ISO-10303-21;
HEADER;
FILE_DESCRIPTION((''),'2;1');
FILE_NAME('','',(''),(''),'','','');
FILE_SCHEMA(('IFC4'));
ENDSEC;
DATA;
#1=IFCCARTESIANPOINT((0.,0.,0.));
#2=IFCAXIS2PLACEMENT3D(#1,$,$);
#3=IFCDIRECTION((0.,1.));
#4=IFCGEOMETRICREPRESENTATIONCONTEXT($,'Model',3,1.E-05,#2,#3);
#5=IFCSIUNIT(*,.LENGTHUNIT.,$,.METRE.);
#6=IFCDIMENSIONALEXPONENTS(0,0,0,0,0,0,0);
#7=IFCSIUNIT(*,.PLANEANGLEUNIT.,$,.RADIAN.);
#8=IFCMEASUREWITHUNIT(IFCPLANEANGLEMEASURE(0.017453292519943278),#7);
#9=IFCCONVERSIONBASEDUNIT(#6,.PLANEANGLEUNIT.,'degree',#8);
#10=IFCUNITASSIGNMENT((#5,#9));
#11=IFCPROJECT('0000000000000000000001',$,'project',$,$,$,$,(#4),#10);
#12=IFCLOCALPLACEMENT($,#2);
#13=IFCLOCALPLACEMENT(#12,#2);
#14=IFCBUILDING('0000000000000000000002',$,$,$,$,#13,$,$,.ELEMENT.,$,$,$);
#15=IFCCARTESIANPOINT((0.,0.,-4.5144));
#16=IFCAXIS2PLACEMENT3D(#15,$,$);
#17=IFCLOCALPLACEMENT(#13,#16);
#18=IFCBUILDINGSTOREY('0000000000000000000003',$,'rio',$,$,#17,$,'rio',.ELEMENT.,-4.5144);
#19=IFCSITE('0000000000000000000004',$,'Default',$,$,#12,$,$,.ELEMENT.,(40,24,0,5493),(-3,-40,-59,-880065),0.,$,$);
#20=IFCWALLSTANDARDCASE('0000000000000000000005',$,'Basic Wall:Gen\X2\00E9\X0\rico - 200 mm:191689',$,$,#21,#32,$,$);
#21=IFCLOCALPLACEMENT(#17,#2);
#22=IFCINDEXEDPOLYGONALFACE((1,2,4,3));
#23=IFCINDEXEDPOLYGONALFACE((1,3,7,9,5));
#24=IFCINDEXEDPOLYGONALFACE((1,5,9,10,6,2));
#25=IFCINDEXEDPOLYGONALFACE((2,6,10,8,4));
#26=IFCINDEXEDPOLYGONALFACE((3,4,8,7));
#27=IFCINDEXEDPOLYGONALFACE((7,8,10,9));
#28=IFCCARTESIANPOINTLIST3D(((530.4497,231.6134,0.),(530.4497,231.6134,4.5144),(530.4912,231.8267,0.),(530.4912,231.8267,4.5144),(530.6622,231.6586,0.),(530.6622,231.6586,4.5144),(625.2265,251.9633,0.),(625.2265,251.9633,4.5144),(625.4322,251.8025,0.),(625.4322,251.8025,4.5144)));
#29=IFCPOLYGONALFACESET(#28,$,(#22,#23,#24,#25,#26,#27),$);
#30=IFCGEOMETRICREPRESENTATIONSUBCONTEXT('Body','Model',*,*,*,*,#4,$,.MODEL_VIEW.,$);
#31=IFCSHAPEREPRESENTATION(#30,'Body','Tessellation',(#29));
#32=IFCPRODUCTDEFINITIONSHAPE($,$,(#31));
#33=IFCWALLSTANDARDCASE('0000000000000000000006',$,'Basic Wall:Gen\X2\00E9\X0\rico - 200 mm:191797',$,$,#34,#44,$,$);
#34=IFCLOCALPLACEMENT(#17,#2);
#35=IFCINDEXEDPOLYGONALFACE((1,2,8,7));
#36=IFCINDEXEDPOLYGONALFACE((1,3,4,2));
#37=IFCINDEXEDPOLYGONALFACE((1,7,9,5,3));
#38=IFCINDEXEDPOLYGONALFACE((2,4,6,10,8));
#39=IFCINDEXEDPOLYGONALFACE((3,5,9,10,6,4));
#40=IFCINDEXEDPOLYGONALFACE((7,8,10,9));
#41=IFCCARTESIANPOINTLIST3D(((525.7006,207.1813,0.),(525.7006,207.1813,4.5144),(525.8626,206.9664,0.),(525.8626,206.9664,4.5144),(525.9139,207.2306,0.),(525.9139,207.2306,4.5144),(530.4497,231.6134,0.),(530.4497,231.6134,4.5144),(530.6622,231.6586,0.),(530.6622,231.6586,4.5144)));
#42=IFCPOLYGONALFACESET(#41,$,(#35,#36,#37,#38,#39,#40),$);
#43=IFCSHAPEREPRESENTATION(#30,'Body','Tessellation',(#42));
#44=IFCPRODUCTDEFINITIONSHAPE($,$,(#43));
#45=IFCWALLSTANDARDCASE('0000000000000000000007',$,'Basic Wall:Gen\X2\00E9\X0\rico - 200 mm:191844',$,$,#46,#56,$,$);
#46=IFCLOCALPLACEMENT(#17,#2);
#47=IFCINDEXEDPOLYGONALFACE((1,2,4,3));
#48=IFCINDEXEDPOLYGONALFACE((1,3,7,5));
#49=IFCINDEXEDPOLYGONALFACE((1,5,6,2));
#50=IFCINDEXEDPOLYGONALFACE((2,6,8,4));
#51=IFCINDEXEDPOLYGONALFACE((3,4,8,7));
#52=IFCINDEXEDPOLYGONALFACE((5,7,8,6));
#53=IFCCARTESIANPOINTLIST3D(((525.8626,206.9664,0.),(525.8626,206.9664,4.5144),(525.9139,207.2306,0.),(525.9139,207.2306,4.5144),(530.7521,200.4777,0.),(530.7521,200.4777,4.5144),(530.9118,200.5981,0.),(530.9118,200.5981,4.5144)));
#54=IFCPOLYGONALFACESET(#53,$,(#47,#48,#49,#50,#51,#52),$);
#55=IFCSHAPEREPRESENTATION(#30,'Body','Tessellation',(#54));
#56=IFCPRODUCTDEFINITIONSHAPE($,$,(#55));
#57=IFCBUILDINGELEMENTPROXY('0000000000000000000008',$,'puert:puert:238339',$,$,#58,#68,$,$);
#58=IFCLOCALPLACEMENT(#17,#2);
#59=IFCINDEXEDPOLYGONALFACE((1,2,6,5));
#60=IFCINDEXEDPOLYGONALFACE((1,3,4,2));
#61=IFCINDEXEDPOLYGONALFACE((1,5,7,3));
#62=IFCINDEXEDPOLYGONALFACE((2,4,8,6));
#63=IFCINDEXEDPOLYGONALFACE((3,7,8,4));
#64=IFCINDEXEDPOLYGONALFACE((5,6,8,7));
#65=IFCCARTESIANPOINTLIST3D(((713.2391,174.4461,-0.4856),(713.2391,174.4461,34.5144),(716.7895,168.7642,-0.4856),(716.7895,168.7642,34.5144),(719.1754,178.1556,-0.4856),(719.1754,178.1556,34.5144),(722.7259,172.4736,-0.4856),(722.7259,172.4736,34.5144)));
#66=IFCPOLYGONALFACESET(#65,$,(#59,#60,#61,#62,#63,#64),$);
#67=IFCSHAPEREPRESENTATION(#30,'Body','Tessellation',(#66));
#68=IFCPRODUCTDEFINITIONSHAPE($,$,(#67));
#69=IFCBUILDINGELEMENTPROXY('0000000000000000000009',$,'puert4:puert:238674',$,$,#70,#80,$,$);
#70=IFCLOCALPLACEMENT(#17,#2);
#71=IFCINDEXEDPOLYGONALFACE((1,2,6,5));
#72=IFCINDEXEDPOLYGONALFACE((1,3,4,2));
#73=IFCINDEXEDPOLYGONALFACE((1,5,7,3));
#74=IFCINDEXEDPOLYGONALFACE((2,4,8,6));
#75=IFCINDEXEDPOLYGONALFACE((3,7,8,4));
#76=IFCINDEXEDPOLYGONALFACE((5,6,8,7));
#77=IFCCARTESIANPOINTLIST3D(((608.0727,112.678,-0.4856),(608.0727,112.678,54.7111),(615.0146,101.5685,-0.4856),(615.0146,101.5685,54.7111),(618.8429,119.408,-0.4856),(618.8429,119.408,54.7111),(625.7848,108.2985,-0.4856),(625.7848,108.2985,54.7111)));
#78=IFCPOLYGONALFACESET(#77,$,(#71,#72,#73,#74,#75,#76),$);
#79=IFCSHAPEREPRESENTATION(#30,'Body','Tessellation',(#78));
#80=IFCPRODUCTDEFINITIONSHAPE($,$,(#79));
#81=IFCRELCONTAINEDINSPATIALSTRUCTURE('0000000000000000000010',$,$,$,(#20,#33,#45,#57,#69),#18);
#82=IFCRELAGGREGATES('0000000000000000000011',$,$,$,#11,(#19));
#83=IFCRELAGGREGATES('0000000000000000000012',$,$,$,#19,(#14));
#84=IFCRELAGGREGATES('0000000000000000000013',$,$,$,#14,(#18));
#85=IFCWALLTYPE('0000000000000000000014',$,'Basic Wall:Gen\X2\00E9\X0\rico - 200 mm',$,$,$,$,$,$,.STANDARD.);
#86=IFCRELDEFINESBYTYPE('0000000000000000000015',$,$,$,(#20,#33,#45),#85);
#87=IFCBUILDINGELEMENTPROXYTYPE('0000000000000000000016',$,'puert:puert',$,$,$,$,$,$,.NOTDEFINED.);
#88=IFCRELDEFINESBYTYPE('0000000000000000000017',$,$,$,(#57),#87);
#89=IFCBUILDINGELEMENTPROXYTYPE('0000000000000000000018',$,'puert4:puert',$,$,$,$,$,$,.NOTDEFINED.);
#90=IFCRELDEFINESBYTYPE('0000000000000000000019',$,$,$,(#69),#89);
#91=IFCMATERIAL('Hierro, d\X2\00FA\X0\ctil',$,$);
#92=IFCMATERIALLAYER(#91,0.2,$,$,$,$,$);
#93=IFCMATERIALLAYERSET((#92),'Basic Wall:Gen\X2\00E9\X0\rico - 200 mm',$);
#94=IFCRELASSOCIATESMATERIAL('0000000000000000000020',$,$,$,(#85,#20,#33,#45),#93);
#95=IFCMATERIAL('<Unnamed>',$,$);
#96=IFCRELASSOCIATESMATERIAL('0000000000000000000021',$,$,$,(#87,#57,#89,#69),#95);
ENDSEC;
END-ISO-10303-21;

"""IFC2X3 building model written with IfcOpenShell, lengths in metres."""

from ifc_helpers import new_model, entity, si_unit, converted_unit, direction, frame, frame_2d, origin, origin_2d_with_axis, place, context, subcontext, project, spatial, polyline, rectangle, outline, extrude, source, transform, mapped, material, layer, layer_set, layer_usage, type_object, type_shapes, element, save


model = new_model("IFC2X3")

# Units and contexts
model_context = context("Model", 3, precision=1e-05, world=origin(), true_north=direction((0.0, 1.0)))
body_context = subcontext(model_context, "Body", "Model", "MODEL_VIEW")
ifc_project = project(units=[si_unit("LENGTHUNIT", "METRE"), converted_unit("PLANEANGLEUNIT", "degree", entity("IfcPlaneAngleMeasure", 0.017453292519943278), si_unit("PLANEANGLEUNIT", "RADIAN"), dimensions=[0, 0, 0, 0, 0, 0, 0])], contexts=[model_context])

# Site, building, storey
site_placement = place(None, origin())
site = spatial("IfcSite", under=ifc_project, at=site_placement, Name="Default", CompositionType="ELEMENT", RefLatitude=(40, 24, 0, 5493), RefLongitude=(-3, -40, -59, -880065), RefElevation=0.0)
building_placement = place(site_placement, origin())
building = spatial("IfcBuilding", under=site, at=building_placement, CompositionType="ELEMENT")
storey_placement = place(building_placement, frame((0.0, 0.0, -4.5144)))
storey = spatial("IfcBuildingStorey", under=building, at=storey_placement, Name="rio", LongName="rio", CompositionType="ELEMENT", Elevation=-4.5144)

# Walls
ifc_material_1 = material(Name="Hierro, dúctil")
ifc_layer_1 = layer(ifc_material_1, 0.2)
ifc_layer_set_1 = layer_set([ifc_layer_1], Name="Basic Wall:Genérico - 200 mm")
wall_type = type_object("IfcWallType", Name="Basic Wall:Genérico - 200 mm", PredefinedType="STANDARD", material=ifc_layer_set_1)
ifc_layer_usage_1 = layer_usage(ifc_layer_set_1, "AXIS2", "NEGATIVE", 0.1)
wall_1_placement = place(storey_placement, frame((625.4114, 251.9003, 0.0), z_axis=(0.0, 0.0, 1.0), x_axis=(-0.978148, -0.207912, 0.0)))
element("IfcWallStandardCase", 1, at=wall_1_placement, inside=storey, type_object=wall_type, material=ifc_layer_usage_1, Name="Basic Wall:Genérico - 200 mm:191689", context=body_context, shape_type="SweptSolid", body=[
    extrude(outline(polyline([(97.0196, -0.1), (97.1045, 0.1), (96.8872, 0.1), (0.0, 0.1), (0.1678, -0.1), (97.0196, -0.1)])), origin(), (0.0, 0.0, 1.0), 4.5144),
])
ifc_layer_usage_2 = layer_usage(ifc_layer_set_1, "AXIS2", "NEGATIVE", 0.1)
wall_2_placement = place(storey_placement, frame((530.5641, 231.6776, 0.0), z_axis=(0.0, 0.0, 1.0), x_axis=(-0.190809, -0.981627, 0.0)))
element("IfcWallStandardCase", 2, at=wall_2_placement, inside=storey, type_object=wall_type, material=ifc_layer_usage_2, Name="Basic Wall:Genérico - 200 mm:191797", context=body_context, shape_type="SweptSolid", body=[
    extrude(outline(polyline([(24.9742, -0.1), (25.1543, 0.1), (24.8852, 0.1), (0.0, 0.1), (0.0849, -0.1), (24.9742, -0.1)])), origin(), (0.0, 0.0, 1.0), 4.5144),
])
ifc_layer_usage_3 = layer_usage(ifc_layer_set_1, "AXIS2", "NEGATIVE", 0.1)
wall_3_placement = place(storey_placement, frame((525.834, 207.1704, 0.0), z_axis=(0.0, 0.0, 1.0), x_axis=(0.601815, -0.798636, 0.0)))
element("IfcWallStandardCase", 3, at=wall_3_placement, inside=storey, type_object=wall_type, material=ifc_layer_usage_3, Name="Basic Wall:Genérico - 200 mm:191844", context=body_context, shape_type="SweptSolid", body=[
    extrude(outline(polyline([(8.3047, -0.1), (8.3047, 0.1), (0.0, 0.1), (0.1801, -0.1), (8.3047, -0.1)])), origin(), (0.0, 0.0, 1.0), 4.5144),
])

# Building element proxies
ifc_material_2 = material(Name="<Unnamed>")
building_element_proxy_type_1 = type_object("IfcBuildingElementProxyType", Name="puert:puert", PredefinedType="NOTDEFINED", material=ifc_material_2)
shared_shape_1 = source(origin(), body_context, "Body", "SweptSolid", [
    extrude(rectangle(XDim=7.0, YDim=6.7, at=origin_2d_with_axis()), frame((717.9825, 173.4599, -5.0), z_axis=(0.0, 0.0, 1.0), x_axis=(-0.848048, -0.529919, 0.0)), (0.0, 0.0, 1.0), 35.0),
])
type_shapes(building_element_proxy_type_1, [shared_shape_1])
proxy_1_placement = place(storey_placement, frame((0.0, 0.0, 4.5144)))
element("IfcBuildingElementProxy", 4, at=proxy_1_placement, inside=storey, type_object=building_element_proxy_type_1, material=ifc_material_2, Name="puert:puert:238339", context=body_context, shape_type="MappedRepresentation", body=[
    mapped(shared_shape_1, transform((0.0, 0.0, 0.0), scale=1.0)),
])
building_element_proxy_type_2 = type_object("IfcBuildingElementProxyType", Name="puert4:puert", PredefinedType="NOTDEFINED", material=ifc_material_2)
shared_shape_2 = source(origin(), body_context, "Body", "SweptSolid", [
    extrude(rectangle(XDim=12.7, YDim=13.1, at=frame_2d((0.0, 0.0), x_axis=(1.0, 0.0))), frame((616.9287, 110.4883, -5.0), z_axis=(0.0, 0.0, 1.0), x_axis=(-0.848048, -0.529919, 0.0)), (0.0, 0.0, 1.0), 55.1967),
])
type_shapes(building_element_proxy_type_2, [shared_shape_2])
proxy_2_placement = place(storey_placement, frame((0.0, 0.0, 4.5144)))
element("IfcBuildingElementProxy", 5, at=proxy_2_placement, inside=storey, type_object=building_element_proxy_type_2, material=ifc_material_2, Name="puert4:puert:238674", context=body_context, shape_type="MappedRepresentation", body=[
    mapped(shared_shape_2, transform((0.0, 0.0, 0.0), scale=1.0)),
])

save(model, "model.ifc")
